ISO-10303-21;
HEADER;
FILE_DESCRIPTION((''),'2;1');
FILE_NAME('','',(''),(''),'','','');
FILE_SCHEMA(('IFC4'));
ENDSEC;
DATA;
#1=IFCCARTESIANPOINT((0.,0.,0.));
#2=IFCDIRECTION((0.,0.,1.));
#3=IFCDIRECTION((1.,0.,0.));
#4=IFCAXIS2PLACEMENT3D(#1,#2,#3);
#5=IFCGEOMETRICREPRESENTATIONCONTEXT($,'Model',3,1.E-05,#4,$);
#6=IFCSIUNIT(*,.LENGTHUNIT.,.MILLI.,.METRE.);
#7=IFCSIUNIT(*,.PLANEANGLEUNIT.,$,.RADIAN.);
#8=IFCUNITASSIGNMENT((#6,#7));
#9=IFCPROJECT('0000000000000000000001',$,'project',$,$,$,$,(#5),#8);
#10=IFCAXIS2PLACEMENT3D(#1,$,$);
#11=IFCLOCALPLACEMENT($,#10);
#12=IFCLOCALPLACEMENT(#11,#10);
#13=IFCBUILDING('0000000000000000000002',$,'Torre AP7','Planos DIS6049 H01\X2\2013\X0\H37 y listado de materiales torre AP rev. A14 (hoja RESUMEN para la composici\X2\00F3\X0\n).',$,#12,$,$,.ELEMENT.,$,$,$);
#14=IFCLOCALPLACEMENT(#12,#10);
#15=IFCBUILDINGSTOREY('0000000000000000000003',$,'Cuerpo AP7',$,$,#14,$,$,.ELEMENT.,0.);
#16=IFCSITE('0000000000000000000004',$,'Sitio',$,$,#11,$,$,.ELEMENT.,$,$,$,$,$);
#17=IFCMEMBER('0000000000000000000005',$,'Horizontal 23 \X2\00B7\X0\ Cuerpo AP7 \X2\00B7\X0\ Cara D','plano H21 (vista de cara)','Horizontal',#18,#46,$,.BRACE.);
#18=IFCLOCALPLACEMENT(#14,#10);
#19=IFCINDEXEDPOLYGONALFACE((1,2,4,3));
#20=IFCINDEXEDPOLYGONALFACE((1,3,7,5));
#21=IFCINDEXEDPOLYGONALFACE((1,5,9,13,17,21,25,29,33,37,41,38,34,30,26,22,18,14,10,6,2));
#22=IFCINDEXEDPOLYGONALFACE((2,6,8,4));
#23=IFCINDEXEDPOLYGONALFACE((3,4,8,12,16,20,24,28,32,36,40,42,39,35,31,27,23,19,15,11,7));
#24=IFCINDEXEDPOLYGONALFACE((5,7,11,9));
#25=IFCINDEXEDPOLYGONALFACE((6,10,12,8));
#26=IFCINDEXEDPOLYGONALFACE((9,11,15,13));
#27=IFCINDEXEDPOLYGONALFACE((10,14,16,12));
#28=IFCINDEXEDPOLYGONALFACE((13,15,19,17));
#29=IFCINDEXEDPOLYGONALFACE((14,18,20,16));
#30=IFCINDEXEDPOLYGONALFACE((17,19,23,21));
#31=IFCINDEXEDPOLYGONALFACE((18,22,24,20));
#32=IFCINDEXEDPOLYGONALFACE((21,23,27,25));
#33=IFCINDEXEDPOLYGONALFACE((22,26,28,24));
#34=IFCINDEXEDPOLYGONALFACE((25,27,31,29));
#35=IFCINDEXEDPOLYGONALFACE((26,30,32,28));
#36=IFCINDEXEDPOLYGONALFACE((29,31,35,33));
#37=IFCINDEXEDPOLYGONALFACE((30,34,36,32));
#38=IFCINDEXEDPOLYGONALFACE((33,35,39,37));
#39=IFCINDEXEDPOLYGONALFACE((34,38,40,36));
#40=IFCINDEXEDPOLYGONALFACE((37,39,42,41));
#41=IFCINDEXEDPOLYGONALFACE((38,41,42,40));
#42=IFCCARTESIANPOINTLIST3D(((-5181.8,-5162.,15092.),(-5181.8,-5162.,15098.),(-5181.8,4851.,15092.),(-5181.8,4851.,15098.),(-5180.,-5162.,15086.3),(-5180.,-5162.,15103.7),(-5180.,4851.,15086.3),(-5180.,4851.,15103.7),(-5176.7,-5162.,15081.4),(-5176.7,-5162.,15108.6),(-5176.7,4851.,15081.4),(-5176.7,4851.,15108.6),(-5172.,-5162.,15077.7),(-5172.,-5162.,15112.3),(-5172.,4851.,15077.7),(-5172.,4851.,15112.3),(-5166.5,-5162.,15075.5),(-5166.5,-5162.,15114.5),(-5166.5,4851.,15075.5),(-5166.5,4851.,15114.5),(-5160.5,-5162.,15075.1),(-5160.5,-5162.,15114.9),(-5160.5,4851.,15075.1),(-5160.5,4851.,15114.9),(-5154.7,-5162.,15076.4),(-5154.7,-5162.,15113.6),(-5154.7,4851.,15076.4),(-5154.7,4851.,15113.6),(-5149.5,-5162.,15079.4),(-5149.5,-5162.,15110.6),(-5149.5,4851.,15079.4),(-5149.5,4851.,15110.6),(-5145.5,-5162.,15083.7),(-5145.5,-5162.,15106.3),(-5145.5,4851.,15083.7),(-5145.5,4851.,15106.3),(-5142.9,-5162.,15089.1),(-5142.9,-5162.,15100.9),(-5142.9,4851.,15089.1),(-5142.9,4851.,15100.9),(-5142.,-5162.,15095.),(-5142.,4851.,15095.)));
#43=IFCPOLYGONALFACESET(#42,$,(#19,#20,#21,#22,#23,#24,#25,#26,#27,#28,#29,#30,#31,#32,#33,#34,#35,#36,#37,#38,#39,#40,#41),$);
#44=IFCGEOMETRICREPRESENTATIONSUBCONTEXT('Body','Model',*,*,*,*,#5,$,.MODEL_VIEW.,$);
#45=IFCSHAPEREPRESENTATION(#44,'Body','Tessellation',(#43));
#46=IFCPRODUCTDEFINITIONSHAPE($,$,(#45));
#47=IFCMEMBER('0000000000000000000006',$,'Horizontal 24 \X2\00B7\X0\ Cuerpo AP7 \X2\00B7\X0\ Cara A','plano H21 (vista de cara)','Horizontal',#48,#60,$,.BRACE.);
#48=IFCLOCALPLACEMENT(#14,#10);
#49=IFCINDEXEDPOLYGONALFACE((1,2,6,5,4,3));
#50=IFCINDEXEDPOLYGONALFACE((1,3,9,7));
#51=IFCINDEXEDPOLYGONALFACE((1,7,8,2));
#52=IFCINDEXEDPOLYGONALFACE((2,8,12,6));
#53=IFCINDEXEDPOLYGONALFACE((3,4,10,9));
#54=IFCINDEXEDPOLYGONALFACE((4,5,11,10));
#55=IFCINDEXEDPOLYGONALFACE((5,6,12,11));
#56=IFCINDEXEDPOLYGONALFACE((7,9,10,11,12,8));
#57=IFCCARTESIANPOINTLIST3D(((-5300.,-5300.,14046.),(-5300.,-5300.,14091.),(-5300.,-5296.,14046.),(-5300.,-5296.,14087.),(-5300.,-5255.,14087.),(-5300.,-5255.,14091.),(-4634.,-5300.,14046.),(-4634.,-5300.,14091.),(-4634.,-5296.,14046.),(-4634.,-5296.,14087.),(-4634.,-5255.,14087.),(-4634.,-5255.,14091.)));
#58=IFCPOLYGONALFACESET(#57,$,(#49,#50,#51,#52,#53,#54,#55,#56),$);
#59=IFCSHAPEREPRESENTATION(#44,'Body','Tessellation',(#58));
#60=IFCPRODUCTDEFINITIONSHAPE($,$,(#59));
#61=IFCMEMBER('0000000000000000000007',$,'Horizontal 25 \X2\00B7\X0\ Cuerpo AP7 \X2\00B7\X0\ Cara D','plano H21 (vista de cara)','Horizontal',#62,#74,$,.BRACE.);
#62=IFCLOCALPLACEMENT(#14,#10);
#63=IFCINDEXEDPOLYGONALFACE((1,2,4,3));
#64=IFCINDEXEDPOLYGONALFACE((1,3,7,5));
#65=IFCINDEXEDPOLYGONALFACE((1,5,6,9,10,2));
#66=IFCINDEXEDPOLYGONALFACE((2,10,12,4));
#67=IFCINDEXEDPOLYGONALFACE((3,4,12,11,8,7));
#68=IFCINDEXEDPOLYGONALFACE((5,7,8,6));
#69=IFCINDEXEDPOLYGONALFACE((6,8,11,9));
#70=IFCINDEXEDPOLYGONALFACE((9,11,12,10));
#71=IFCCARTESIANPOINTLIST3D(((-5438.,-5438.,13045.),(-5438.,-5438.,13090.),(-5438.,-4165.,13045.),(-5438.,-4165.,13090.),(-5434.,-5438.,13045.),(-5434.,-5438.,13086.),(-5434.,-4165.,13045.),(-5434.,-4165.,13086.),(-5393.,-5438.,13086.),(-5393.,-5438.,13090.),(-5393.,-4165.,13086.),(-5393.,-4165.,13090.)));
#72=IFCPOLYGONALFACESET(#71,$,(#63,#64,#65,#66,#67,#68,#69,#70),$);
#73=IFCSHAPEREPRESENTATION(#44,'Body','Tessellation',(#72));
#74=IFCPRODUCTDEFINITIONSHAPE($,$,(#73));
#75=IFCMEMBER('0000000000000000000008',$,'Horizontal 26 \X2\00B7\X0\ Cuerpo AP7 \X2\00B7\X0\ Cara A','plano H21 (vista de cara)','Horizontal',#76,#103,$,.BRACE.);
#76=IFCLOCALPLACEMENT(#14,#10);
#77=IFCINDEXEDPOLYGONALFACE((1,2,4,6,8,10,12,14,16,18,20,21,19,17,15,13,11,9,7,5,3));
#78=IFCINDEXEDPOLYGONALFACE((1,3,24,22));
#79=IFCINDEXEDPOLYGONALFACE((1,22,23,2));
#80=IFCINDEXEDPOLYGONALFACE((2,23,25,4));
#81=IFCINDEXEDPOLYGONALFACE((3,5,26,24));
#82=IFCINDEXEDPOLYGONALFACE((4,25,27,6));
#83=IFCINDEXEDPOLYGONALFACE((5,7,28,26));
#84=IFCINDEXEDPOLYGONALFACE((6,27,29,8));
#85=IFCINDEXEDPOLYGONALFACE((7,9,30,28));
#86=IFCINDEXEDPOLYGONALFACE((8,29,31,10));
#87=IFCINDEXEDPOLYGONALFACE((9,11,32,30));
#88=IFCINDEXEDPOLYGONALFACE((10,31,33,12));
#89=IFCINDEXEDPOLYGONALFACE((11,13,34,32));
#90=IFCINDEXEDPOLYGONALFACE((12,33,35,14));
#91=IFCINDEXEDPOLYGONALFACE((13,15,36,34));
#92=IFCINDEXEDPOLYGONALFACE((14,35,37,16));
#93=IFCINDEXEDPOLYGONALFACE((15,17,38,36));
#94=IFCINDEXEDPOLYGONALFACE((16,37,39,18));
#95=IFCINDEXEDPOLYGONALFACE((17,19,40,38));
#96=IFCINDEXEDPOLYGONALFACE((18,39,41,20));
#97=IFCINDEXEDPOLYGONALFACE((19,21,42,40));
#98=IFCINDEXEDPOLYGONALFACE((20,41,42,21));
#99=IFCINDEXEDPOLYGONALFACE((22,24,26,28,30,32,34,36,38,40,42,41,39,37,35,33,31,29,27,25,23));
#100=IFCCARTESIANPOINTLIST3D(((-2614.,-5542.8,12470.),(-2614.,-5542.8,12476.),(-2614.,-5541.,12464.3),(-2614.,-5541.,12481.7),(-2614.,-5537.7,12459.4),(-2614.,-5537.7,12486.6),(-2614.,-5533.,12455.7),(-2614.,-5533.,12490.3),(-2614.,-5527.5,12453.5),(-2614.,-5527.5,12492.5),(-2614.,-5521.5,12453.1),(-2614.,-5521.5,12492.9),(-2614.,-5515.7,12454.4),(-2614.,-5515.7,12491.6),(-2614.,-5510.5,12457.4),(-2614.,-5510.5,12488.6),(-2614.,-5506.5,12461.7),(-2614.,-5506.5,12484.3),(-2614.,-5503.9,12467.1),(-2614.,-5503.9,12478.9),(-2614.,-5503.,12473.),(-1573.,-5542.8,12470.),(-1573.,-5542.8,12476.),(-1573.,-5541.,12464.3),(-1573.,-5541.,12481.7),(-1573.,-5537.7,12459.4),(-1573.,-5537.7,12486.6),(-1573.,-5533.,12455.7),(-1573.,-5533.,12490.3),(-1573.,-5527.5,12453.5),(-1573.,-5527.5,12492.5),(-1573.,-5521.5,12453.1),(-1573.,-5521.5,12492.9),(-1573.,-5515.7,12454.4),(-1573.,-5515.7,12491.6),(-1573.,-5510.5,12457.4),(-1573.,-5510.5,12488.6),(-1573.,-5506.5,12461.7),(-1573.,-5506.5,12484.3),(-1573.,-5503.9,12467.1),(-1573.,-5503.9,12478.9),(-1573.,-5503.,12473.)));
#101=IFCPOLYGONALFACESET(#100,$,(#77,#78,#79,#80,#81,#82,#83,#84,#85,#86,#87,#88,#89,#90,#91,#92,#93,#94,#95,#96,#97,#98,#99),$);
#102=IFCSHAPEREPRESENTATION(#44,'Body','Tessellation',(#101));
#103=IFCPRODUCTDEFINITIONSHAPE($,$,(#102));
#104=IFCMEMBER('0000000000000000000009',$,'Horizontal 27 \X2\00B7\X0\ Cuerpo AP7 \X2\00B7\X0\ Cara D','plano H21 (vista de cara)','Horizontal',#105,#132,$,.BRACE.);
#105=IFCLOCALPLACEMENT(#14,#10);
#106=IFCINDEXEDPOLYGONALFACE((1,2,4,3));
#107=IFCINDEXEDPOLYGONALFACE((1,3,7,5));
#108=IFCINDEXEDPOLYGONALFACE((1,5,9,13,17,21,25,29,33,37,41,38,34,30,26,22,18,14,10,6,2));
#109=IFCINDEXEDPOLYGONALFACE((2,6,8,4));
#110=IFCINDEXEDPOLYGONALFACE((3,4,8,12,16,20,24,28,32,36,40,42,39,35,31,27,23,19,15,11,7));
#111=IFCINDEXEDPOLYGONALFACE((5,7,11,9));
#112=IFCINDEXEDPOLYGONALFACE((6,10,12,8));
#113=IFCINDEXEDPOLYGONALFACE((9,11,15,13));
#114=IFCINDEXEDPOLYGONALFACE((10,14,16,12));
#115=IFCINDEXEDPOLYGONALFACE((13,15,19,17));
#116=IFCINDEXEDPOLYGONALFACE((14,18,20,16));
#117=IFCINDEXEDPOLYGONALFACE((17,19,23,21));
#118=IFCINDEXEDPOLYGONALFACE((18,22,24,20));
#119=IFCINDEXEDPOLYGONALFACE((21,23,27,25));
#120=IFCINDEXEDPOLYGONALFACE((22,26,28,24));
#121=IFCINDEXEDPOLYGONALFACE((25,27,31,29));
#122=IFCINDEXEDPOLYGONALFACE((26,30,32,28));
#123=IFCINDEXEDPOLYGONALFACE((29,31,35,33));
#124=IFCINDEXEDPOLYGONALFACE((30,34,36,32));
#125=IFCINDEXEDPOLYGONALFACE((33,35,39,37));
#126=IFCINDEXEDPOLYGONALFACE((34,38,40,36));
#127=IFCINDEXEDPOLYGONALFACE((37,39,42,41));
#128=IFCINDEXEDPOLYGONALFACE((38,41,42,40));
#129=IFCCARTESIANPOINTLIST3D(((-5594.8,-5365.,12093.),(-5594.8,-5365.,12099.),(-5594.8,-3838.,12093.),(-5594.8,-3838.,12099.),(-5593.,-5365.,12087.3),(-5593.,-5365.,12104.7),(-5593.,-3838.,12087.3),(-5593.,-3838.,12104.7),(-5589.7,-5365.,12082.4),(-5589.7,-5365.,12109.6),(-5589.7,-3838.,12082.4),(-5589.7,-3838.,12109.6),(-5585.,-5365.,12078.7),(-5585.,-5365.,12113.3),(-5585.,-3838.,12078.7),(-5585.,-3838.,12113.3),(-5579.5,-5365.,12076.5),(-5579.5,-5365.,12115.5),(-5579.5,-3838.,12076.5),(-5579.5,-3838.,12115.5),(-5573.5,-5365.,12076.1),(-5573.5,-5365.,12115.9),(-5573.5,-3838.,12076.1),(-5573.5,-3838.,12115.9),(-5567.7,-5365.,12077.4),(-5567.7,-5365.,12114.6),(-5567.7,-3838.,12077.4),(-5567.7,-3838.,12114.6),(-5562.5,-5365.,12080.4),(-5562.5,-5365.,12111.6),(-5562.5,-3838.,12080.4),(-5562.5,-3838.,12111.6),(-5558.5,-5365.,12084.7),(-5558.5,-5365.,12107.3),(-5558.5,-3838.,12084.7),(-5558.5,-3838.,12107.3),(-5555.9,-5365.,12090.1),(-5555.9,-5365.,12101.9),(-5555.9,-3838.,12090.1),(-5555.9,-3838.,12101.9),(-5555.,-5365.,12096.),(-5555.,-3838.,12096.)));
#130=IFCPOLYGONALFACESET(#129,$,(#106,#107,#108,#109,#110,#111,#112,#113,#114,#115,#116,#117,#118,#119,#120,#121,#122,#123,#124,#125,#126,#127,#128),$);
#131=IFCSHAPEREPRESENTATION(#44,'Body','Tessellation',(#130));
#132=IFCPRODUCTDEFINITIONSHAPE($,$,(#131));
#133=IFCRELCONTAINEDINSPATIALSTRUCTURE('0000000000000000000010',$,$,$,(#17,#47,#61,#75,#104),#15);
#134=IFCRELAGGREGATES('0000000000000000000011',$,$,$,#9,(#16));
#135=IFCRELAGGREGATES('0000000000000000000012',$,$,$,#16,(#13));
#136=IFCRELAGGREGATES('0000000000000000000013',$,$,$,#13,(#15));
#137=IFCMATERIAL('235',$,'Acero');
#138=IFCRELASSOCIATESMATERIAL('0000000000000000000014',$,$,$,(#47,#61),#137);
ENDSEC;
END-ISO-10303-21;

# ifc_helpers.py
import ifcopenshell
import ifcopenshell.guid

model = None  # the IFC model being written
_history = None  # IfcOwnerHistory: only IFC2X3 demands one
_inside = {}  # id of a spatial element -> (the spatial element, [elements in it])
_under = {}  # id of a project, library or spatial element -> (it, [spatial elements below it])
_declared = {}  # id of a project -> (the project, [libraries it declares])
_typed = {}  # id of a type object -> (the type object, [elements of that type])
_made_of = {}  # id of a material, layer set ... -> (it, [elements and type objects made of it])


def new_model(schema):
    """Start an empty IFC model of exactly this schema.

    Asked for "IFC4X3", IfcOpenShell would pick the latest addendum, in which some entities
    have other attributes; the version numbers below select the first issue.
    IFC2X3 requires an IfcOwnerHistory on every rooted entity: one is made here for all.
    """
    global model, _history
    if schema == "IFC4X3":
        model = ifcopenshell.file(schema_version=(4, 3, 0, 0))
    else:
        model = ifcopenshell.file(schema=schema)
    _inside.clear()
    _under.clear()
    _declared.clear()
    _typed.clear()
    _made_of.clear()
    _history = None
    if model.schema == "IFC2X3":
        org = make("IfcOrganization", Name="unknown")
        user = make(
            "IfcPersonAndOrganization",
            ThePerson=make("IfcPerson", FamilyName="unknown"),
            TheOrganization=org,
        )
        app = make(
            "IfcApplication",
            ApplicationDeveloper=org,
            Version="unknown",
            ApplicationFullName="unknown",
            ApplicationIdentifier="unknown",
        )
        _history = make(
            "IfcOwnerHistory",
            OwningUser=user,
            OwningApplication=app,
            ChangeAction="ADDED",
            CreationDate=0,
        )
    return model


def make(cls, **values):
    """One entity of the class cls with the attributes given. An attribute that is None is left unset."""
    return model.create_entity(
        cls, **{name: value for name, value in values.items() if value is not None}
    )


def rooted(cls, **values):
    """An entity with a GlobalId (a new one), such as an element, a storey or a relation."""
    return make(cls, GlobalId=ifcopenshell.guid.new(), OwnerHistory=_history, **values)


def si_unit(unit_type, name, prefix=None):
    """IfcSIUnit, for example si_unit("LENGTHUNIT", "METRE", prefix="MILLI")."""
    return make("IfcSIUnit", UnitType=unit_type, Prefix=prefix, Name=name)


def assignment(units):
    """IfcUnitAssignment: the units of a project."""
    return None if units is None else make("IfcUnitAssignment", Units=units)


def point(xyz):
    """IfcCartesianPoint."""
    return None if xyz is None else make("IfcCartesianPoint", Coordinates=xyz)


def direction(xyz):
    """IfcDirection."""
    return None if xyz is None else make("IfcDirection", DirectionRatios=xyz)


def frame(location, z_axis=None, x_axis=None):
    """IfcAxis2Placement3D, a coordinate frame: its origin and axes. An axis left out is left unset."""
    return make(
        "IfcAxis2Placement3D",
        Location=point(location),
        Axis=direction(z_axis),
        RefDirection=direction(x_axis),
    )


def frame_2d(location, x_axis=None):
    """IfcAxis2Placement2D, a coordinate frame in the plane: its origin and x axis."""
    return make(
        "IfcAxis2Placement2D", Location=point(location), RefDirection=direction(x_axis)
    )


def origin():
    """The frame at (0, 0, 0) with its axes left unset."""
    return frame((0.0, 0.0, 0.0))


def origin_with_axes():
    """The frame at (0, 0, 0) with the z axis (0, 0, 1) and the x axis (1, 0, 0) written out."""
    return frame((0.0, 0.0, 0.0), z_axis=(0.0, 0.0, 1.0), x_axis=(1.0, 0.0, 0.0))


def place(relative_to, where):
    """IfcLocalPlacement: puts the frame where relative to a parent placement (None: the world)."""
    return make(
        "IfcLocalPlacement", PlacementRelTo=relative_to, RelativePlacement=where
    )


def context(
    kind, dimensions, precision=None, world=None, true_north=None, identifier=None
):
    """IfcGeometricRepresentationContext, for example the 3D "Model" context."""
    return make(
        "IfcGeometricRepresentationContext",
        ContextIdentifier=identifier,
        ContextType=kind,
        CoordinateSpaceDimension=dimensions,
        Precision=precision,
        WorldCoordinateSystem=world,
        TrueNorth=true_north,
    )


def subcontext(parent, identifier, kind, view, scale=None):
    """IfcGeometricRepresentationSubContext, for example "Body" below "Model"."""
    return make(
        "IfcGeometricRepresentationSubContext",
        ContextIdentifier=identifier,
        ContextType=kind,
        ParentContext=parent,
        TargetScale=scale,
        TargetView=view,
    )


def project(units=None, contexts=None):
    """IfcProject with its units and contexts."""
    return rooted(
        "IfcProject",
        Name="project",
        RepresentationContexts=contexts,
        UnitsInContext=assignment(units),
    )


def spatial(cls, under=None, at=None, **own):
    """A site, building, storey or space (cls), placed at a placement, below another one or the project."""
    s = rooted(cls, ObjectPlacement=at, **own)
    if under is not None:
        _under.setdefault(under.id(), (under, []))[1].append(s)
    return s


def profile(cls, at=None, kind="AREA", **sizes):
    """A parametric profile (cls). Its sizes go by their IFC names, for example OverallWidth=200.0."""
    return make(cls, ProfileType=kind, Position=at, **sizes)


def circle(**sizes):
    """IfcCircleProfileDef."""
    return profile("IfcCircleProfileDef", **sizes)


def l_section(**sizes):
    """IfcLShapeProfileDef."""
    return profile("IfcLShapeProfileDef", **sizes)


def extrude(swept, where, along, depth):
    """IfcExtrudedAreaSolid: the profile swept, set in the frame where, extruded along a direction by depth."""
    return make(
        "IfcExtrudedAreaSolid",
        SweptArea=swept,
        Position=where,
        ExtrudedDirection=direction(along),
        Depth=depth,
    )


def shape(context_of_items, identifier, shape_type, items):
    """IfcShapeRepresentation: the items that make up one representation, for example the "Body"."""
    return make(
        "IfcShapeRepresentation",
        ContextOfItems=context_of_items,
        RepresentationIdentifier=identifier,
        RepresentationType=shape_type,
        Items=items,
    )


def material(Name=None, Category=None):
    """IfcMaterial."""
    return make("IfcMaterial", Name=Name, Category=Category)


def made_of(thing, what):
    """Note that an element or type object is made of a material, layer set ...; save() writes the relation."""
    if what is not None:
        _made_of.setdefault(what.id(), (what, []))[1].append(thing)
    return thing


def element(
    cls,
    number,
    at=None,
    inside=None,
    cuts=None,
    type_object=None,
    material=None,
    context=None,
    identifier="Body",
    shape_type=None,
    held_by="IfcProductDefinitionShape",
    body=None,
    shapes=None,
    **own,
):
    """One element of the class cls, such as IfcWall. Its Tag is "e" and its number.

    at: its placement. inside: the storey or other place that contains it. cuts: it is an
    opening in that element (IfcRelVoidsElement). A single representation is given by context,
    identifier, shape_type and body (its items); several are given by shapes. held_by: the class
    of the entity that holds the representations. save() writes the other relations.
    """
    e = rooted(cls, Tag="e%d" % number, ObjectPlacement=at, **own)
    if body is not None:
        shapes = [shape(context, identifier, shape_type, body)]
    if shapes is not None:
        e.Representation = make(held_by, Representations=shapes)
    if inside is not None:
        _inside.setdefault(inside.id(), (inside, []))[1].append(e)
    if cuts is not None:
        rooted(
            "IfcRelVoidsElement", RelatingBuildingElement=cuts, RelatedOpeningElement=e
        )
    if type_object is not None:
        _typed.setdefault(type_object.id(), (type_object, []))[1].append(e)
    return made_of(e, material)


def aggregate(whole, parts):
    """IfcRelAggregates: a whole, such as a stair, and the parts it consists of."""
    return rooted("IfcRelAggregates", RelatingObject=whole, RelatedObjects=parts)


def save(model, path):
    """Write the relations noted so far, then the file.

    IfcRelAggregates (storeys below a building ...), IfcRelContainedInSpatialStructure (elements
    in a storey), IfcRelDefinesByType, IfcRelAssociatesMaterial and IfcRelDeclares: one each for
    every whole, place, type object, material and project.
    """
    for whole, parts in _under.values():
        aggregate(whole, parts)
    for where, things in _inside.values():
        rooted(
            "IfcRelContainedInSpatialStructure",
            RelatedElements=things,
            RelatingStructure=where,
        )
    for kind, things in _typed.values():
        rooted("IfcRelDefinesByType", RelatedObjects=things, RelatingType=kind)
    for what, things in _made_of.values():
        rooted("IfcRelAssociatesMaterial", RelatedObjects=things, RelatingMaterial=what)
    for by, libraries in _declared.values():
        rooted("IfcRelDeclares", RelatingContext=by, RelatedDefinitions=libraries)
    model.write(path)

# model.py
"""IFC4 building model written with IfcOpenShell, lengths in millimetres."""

from ifc_helpers import new_model, si_unit, frame, frame_2d, origin, origin_with_axes, place, context, subcontext, project, spatial, circle, l_section, extrude, material, element, save


model = new_model("IFC4")

# Units and contexts
model_context = context("Model", 3, precision=1e-05, world=origin_with_axes())
body_context = subcontext(model_context, "Body", "Model", "MODEL_VIEW")
ifc_project = project(units=[si_unit("LENGTHUNIT", "METRE", prefix="MILLI"), si_unit("PLANEANGLEUNIT", "RADIAN")], contexts=[model_context])

# Site, building, storey
site_placement = place(None, origin())
site = spatial("IfcSite", under=ifc_project, at=site_placement, Name="Sitio", CompositionType="ELEMENT")
building_placement = place(site_placement, origin())
building = spatial("IfcBuilding", under=site, at=building_placement, Name="Torre AP7", Description="Planos DIS6049 H01–H37 y listado de materiales torre AP rev. A14 (hoja RESUMEN para la composición).", CompositionType="ELEMENT")
storey_placement = place(building_placement, origin())
storey = spatial("IfcBuildingStorey", under=building, at=storey_placement, Name="Cuerpo AP7", CompositionType="ELEMENT", Elevation=0.0)

# Members
ifc_material_1 = material(Name="235", Category="Acero")
member_1_placement = place(storey_placement, frame((-5162.0, -5162.0, 15095.0), z_axis=(0.0, 1.0, 0.0), x_axis=(1.0, 0.0, 0.0)))
element("IfcMember", 1, at=member_1_placement, inside=storey, Name="Horizontal 23 · Cuerpo AP7 · Cara D", Description="plano H21 (vista de cara)", ObjectType="Horizontal", PredefinedType="BRACE", context=body_context, shape_type="SweptSolid", body=[
    extrude(circle(Radius=20.0), None, (0.0, 0.0, 1.0), 10013.0),
])
member_2_placement = place(storey_placement, frame((-4634.0, -5300.0, 14091.0), z_axis=(-1.0, 0.0, 0.0), x_axis=(0.0, 1.0, 0.0)))
element("IfcMember", 2, at=member_2_placement, inside=storey, material=ifc_material_1, Name="Horizontal 24 · Cuerpo AP7 · Cara A", Description="plano H21 (vista de cara)", ObjectType="Horizontal", PredefinedType="BRACE", context=body_context, shape_type="SweptSolid", body=[
    extrude(l_section(Depth=45.0, Width=45.0, Thickness=4.0, at=frame_2d((22.5, 22.5))), None, (0.0, 0.0, 1.0), 666.0),
])
member_3_placement = place(storey_placement, frame((-5438.0, -5438.0, 13090.0), z_axis=(0.0, 1.0, 0.0), x_axis=(1.0, 0.0, 0.0)))
element("IfcMember", 3, at=member_3_placement, inside=storey, material=ifc_material_1, Name="Horizontal 25 · Cuerpo AP7 · Cara D", Description="plano H21 (vista de cara)", ObjectType="Horizontal", PredefinedType="BRACE", context=body_context, shape_type="SweptSolid", body=[
    extrude(l_section(Depth=45.0, Width=45.0, Thickness=4.0, at=frame_2d((22.5, 22.5))), None, (0.0, 0.0, 1.0), 1273.0),
])
member_4_placement = place(storey_placement, frame((-1573.0, -5523.0, 12473.0), z_axis=(-1.0, 0.0, 0.0), x_axis=(0.0, 1.0, 0.0)))
element("IfcMember", 4, at=member_4_placement, inside=storey, Name="Horizontal 26 · Cuerpo AP7 · Cara A", Description="plano H21 (vista de cara)", ObjectType="Horizontal", PredefinedType="BRACE", context=body_context, shape_type="SweptSolid", body=[
    extrude(circle(Radius=20.0), None, (0.0, 0.0, 1.0), 1041.0),
])
member_5_placement = place(storey_placement, frame((-5575.0, -5365.0, 12096.0), z_axis=(0.0, 1.0, 0.0), x_axis=(1.0, 0.0, 0.0)))
element("IfcMember", 5, at=member_5_placement, inside=storey, Name="Horizontal 27 · Cuerpo AP7 · Cara D", Description="plano H21 (vista de cara)", ObjectType="Horizontal", PredefinedType="BRACE", context=body_context, shape_type="SweptSolid", body=[
    extrude(circle(Radius=20.0), None, (0.0, 0.0, 1.0), 1527.0),
])

save(model, "model.ifc")
